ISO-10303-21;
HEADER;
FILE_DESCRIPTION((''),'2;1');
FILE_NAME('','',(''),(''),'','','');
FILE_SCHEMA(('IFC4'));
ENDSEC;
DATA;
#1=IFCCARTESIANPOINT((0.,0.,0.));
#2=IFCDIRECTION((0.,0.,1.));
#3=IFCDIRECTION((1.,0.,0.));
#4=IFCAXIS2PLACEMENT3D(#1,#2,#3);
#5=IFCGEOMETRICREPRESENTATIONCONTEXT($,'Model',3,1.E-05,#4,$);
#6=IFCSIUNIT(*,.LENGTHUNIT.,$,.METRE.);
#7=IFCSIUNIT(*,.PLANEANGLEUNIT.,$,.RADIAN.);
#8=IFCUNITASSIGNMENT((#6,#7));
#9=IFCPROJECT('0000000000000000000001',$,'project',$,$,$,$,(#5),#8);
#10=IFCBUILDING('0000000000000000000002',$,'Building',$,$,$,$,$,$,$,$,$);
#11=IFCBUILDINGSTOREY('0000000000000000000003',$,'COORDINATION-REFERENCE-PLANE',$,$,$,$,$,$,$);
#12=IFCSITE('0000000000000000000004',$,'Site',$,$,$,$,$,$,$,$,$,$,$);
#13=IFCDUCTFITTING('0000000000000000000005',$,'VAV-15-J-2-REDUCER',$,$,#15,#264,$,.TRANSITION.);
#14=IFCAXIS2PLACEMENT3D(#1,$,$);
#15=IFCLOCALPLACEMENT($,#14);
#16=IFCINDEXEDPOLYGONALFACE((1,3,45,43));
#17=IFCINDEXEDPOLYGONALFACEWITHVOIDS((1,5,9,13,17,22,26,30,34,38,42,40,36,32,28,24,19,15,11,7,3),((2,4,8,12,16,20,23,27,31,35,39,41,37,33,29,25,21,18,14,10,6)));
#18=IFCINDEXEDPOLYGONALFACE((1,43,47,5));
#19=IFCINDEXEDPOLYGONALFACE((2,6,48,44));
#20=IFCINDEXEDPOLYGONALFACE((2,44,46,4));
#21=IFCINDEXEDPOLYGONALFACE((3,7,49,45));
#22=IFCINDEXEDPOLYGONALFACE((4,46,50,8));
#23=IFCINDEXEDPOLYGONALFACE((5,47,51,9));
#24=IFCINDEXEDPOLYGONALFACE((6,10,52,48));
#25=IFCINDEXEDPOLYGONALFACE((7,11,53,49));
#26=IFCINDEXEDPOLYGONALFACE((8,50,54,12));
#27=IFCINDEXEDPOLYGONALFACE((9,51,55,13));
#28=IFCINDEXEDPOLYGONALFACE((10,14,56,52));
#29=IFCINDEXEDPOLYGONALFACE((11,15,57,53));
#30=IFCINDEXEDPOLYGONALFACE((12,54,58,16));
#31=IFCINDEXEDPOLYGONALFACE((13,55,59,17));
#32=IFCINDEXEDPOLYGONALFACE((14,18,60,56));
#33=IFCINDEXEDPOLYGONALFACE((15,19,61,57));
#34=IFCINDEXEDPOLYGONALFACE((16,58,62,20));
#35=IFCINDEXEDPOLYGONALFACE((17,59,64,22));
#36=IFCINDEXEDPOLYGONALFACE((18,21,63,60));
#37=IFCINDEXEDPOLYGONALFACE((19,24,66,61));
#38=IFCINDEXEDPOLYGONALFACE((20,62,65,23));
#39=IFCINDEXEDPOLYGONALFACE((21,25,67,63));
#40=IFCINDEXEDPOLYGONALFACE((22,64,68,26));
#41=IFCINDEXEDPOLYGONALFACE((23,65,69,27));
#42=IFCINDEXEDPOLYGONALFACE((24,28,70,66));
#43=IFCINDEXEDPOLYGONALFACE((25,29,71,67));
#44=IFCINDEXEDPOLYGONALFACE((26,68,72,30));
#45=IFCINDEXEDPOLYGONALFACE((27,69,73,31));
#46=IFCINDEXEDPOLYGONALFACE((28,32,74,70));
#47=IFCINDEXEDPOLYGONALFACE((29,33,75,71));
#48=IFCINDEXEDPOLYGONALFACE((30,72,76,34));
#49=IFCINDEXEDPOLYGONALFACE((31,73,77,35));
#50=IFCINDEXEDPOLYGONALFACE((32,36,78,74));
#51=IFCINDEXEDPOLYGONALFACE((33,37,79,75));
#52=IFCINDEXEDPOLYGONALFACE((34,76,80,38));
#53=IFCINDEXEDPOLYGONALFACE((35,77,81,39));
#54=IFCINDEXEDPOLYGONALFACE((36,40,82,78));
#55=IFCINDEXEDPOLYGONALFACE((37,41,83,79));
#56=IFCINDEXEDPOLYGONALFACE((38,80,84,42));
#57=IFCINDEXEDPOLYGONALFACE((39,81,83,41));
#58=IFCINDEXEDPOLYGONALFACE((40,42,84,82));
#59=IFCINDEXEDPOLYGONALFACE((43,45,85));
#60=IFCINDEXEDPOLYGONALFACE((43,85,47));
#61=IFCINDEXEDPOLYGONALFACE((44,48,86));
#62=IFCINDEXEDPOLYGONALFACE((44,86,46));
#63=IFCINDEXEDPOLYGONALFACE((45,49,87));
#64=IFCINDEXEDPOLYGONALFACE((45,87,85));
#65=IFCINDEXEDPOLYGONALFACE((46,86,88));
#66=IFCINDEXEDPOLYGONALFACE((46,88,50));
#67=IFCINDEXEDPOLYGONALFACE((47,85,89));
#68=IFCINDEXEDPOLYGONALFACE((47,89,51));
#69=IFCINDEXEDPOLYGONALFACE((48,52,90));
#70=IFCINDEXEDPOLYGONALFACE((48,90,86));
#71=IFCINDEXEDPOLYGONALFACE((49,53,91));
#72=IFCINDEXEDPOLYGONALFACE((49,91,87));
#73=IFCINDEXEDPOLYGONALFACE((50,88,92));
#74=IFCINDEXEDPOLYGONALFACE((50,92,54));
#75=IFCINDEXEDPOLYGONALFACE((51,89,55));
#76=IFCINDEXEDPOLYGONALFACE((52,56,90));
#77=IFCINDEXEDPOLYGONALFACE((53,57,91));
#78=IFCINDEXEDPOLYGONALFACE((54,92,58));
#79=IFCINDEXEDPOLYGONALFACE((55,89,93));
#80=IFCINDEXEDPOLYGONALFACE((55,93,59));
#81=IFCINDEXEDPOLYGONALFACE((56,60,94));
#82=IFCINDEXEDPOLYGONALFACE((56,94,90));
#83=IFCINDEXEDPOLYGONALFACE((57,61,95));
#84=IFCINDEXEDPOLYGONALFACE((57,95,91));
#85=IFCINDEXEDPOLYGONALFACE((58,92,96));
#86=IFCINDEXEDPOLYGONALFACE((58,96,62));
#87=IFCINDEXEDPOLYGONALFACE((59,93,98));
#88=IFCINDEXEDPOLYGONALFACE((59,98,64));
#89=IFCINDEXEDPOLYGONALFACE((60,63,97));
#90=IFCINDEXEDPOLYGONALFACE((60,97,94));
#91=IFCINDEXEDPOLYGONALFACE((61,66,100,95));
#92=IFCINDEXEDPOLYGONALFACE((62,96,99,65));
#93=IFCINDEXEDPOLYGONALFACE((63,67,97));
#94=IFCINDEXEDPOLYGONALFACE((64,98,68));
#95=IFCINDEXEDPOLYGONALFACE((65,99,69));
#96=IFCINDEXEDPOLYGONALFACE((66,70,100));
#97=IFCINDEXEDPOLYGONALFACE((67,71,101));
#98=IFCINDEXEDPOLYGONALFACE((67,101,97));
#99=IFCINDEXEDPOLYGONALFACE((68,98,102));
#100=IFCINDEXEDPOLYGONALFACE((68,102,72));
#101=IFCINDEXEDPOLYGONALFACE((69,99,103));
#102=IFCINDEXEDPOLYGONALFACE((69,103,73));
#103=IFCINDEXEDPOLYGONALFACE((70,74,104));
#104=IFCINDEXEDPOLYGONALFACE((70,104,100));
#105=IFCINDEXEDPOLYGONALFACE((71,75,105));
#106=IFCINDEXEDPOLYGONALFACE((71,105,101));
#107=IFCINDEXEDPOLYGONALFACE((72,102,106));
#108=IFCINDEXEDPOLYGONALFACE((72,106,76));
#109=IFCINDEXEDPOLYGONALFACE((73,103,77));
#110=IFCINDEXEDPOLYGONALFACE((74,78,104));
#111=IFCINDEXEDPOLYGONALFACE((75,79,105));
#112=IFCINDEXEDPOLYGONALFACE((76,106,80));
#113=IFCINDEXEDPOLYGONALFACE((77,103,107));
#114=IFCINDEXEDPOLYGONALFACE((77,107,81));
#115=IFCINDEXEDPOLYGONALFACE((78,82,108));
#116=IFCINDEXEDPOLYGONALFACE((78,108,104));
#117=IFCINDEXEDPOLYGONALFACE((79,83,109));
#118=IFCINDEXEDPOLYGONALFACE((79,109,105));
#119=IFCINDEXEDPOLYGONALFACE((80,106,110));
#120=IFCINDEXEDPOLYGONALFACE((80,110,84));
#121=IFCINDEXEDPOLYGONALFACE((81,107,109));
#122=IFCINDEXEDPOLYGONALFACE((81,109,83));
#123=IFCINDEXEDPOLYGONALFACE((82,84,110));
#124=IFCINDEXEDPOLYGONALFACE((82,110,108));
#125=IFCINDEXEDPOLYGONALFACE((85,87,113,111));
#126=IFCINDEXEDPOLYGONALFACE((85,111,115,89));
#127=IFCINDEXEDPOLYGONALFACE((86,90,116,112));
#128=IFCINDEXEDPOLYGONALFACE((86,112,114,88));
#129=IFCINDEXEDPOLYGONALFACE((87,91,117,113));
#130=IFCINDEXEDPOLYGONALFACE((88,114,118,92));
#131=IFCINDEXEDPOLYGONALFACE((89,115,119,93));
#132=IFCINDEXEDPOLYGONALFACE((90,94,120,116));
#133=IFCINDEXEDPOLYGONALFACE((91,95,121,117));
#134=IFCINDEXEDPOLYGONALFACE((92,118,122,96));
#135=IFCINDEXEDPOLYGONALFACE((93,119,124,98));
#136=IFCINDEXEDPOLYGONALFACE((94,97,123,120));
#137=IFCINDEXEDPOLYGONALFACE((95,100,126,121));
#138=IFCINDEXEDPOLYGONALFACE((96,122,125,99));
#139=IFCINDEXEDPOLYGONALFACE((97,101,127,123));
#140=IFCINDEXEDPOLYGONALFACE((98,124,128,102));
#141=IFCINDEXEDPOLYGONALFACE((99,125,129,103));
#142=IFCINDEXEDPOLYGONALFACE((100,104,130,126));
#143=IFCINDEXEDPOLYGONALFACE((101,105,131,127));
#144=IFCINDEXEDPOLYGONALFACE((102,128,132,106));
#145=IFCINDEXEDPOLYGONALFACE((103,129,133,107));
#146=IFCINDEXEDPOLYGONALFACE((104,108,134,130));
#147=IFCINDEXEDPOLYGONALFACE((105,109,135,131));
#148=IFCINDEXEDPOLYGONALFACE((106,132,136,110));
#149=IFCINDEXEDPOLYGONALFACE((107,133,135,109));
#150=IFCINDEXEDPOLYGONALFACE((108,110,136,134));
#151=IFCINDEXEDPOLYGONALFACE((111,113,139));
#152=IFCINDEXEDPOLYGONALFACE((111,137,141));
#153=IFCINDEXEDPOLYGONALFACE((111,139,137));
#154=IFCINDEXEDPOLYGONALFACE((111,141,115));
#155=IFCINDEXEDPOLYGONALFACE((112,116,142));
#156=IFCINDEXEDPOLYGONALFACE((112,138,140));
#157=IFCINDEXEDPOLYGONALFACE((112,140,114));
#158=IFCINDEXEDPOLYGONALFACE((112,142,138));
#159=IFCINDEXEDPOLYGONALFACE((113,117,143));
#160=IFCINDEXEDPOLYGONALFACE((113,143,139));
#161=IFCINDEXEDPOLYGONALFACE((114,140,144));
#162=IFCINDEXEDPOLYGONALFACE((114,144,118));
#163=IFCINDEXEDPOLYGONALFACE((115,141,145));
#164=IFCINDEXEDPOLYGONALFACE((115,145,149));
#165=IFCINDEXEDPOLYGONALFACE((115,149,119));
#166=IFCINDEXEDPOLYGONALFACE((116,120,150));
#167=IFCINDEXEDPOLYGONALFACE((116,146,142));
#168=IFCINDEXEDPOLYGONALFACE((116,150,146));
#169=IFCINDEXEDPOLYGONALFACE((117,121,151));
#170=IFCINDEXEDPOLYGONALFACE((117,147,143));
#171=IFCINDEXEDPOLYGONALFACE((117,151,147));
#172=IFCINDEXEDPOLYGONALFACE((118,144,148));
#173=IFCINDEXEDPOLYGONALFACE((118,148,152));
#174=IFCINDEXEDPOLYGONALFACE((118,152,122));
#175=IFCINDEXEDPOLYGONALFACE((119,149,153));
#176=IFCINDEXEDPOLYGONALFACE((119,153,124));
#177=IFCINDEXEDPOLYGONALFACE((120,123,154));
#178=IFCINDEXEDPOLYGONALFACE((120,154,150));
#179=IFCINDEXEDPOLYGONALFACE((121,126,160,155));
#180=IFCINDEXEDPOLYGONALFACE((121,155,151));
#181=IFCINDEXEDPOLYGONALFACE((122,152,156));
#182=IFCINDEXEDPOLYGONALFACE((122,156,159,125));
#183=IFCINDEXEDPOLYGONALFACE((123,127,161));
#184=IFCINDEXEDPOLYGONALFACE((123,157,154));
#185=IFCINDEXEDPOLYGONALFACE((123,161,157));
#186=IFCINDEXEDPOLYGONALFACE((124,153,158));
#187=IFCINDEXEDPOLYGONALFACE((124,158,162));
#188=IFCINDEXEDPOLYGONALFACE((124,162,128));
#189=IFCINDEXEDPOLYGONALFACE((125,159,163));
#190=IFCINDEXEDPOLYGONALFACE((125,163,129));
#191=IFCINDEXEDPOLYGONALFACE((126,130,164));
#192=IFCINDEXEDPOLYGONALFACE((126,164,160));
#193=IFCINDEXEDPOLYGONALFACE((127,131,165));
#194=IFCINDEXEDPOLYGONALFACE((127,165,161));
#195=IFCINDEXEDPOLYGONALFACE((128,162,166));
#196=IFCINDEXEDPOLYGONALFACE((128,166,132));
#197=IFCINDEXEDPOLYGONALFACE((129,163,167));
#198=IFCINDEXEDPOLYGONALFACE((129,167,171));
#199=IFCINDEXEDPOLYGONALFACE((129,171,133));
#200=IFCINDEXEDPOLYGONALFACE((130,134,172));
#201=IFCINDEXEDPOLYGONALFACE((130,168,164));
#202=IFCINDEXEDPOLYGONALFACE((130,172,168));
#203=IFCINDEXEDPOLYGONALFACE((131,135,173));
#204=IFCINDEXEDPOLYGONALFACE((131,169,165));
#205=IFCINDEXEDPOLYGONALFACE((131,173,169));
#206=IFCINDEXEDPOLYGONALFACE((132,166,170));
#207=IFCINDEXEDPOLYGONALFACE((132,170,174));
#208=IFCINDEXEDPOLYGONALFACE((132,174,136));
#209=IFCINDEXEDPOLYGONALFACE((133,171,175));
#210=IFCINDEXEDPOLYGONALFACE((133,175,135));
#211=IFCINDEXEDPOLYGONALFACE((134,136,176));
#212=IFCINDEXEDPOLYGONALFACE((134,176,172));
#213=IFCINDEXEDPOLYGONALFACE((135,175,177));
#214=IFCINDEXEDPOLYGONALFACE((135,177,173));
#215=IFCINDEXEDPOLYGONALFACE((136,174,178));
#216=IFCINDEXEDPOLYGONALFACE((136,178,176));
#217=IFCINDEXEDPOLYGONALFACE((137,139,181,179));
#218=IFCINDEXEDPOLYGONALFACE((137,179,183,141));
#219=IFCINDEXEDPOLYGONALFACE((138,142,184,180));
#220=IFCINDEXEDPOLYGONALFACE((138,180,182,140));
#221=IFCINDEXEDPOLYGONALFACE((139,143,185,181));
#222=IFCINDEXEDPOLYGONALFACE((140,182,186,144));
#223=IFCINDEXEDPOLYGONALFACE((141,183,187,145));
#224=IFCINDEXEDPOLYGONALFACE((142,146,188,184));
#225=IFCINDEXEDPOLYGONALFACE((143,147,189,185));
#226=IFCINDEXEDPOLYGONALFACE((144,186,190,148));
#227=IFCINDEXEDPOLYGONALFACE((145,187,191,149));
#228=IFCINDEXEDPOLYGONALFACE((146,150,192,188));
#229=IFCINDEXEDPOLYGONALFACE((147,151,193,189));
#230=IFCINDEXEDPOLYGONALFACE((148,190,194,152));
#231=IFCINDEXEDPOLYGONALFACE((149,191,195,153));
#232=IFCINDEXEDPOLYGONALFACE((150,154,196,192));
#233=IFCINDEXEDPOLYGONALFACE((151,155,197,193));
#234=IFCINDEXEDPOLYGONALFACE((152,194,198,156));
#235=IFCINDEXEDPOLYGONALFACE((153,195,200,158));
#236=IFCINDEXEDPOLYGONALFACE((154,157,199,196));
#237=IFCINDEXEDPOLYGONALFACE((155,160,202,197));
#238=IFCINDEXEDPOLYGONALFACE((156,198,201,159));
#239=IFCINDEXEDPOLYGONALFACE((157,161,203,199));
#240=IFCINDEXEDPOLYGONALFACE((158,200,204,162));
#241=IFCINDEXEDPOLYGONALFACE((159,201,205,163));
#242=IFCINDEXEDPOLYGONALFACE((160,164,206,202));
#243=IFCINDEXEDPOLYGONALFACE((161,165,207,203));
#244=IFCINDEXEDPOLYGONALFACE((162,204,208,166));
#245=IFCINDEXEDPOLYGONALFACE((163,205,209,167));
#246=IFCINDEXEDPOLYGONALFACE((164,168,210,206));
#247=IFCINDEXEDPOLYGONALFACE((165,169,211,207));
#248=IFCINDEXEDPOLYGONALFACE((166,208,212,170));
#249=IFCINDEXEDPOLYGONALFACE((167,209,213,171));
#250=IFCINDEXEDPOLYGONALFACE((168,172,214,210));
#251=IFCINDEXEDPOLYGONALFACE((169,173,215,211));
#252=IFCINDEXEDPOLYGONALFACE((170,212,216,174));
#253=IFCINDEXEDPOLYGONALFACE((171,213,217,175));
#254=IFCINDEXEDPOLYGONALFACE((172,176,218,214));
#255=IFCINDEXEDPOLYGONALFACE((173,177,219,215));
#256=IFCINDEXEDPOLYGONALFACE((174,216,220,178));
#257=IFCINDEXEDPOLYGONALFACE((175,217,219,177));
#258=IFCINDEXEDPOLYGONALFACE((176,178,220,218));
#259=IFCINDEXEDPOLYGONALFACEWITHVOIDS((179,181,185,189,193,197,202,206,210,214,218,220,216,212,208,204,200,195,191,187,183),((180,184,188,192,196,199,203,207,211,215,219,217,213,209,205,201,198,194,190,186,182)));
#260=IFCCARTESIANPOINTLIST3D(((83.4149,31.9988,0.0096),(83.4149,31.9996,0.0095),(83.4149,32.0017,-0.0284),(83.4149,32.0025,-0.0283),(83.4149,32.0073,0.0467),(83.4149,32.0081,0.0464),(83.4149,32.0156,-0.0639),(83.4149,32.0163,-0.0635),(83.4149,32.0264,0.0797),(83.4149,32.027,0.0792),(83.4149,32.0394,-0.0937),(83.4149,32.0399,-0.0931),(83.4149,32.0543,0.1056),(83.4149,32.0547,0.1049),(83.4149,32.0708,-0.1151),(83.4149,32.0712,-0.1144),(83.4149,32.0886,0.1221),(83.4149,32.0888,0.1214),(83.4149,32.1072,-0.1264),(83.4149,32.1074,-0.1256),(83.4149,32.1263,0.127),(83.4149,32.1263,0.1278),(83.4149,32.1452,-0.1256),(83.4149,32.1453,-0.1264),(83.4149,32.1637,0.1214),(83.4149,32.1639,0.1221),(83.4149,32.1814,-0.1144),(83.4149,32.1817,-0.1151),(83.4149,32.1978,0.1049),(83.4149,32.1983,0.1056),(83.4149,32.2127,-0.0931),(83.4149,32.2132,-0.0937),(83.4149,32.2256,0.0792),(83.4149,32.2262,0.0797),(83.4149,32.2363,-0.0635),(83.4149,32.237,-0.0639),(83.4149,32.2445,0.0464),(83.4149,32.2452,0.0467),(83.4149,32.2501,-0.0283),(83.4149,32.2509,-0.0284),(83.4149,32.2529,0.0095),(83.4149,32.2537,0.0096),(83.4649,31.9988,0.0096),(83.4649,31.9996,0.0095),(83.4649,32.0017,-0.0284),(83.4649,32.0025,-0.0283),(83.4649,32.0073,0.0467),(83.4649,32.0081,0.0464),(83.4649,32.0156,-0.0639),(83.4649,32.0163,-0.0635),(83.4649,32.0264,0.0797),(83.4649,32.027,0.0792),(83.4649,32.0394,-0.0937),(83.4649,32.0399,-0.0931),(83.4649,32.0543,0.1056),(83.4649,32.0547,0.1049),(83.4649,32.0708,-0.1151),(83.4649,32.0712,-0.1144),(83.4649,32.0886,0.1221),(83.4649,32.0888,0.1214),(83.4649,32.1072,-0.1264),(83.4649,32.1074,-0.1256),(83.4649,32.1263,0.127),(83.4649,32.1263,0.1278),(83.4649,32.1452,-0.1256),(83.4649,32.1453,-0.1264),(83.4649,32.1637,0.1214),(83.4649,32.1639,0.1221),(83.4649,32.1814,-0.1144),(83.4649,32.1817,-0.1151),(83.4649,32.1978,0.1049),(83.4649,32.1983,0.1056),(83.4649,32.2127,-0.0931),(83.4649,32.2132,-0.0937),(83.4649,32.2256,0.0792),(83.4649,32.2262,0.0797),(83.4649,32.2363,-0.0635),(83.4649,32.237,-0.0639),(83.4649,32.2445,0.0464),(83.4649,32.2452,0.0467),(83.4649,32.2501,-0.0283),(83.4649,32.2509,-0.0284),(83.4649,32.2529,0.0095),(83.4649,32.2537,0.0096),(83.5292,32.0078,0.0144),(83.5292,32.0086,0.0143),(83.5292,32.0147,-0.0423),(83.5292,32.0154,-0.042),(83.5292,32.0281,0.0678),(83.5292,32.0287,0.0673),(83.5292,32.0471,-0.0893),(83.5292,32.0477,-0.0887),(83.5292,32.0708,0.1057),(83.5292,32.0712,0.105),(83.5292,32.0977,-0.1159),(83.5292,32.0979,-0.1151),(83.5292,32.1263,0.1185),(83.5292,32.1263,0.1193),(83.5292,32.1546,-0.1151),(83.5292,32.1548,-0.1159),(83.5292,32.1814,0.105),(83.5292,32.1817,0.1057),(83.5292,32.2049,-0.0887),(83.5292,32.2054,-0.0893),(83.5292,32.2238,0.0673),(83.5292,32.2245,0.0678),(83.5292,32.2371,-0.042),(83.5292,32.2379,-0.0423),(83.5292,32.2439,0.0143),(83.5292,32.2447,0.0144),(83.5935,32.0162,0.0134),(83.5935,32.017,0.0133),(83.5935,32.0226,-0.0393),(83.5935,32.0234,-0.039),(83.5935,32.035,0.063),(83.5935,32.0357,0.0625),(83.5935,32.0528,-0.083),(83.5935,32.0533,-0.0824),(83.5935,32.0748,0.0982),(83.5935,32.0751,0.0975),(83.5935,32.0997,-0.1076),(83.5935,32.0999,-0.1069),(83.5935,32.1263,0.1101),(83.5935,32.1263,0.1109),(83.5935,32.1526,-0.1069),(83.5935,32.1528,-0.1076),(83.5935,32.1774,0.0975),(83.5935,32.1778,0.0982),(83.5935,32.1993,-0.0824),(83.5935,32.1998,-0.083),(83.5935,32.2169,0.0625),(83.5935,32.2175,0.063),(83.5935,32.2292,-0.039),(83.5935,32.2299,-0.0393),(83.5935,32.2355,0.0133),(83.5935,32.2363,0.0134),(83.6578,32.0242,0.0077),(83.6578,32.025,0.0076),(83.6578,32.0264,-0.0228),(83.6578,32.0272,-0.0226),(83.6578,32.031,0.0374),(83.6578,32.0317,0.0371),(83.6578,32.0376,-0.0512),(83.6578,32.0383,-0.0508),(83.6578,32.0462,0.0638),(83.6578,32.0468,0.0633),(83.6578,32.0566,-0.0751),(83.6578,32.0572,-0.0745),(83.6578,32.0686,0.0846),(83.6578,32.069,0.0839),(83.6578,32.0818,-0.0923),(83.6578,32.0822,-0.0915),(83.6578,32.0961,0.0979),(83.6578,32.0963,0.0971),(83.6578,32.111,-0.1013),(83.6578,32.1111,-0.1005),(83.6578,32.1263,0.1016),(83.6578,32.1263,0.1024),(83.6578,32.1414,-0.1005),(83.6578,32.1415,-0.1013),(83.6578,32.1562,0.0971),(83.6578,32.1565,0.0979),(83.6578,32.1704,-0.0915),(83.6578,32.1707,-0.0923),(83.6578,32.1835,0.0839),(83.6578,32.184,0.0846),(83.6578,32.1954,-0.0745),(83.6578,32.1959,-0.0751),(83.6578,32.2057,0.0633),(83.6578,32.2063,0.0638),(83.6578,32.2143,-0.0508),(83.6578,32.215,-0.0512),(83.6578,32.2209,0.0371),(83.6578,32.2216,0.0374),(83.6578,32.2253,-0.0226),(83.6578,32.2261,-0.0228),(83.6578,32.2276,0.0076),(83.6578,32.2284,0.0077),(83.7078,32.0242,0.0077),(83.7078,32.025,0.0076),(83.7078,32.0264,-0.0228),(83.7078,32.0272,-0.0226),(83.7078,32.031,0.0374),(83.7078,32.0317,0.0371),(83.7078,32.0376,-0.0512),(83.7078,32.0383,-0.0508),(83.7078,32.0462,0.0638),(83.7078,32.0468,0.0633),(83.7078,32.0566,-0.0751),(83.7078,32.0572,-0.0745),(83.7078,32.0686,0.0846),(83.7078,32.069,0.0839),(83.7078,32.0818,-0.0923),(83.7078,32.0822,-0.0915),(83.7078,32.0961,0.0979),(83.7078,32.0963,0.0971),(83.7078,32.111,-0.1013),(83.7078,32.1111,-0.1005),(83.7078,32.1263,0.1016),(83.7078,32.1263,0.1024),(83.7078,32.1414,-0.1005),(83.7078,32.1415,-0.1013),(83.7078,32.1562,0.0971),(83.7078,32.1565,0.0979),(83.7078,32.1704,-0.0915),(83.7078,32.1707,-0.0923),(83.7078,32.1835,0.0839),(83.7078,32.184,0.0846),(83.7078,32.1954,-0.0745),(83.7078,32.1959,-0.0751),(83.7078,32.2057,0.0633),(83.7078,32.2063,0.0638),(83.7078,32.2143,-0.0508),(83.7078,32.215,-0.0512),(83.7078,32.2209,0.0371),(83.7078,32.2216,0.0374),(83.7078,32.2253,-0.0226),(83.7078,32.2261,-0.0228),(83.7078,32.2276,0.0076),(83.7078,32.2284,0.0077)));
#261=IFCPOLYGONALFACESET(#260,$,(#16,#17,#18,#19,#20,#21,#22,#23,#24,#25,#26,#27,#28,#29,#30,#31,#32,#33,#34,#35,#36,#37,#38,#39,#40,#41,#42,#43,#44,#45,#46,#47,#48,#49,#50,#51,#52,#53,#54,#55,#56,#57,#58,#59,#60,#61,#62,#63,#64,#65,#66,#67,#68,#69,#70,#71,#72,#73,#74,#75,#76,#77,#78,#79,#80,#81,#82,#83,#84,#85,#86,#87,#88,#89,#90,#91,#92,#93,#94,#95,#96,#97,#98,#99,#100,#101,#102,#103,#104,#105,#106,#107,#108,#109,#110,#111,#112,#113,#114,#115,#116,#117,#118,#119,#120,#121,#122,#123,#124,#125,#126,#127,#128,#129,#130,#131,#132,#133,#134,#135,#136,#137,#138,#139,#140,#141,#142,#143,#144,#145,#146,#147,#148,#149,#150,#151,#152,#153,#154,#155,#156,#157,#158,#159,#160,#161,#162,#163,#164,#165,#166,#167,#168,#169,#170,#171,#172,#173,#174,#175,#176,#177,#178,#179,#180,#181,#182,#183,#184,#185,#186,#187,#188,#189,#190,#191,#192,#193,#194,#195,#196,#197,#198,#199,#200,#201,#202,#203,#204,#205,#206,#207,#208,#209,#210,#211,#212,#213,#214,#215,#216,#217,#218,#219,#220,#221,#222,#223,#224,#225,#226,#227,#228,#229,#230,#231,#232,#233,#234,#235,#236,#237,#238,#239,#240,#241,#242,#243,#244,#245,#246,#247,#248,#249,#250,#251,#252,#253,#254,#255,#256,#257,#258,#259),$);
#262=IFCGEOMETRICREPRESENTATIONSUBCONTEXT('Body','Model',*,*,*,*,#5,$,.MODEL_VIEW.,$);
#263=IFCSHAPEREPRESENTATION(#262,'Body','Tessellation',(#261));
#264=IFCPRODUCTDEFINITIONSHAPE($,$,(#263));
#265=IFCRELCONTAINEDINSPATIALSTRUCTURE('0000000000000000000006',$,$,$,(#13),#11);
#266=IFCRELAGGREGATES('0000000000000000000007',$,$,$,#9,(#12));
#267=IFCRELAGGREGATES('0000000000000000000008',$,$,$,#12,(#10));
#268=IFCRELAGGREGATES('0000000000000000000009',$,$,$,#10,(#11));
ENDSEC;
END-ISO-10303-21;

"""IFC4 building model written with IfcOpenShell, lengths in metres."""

from ifc_helpers import new_model, entity, si_unit, frame, origin_with_axes, place, context, subcontext, project, spatial, element, save


model = new_model("IFC4")

# Units and contexts
model_context = context("Model", 3, precision=1e-05, world=origin_with_axes())
body_context_1 = subcontext(model_context, "Body", "Model", "MODEL_VIEW")
ifc_project = project(units=[si_unit("LENGTHUNIT", "METRE"), si_unit("PLANEANGLEUNIT", "RADIAN")], contexts=[model_context])

# Site, building, storey
site = spatial("IfcSite", under=ifc_project, Name="Site")
building = spatial("IfcBuilding", under=site, Name="Building")
storey = spatial("IfcBuildingStorey", under=building, Name="COORDINATION-REFERENCE-PLANE")

# Duct fitting
for number, where, z_axis, x_axis, name in (
    (1, (83.4149, 32.1263, 0.0), (0.0, 1.0, 0.0), (0.0, 0.0, 1.0), "VAV-15-J-2-REDUCER"),
):
    element("IfcDuctFitting", number, at=place(None, frame(where, z_axis=z_axis, x_axis=x_axis)), inside=storey, Name=name, PredefinedType="TRANSITION", context=body_context_1, shape_type="SweptSolid", body=[
        entity("IfcRevolvedAreaSolid", entity("IfcArbitraryClosedProfileDef", "AREA", None, entity("IfcPolyline", [entity("IfcCartesianPoint", [0.1278, 0.0]), entity("IfcCartesianPoint", [0.1278, 0.05]), entity("IfcCartesianPoint", [0.1024, 0.2429]), entity("IfcCartesianPoint", [0.1024, 0.2929]), entity("IfcCartesianPoint", [0.1016, 0.2929]), entity("IfcCartesianPoint", [0.1016, 0.2429]), entity("IfcCartesianPoint", [0.127, 0.05]), entity("IfcCartesianPoint", [0.127, 0.0]), entity("IfcCartesianPoint", [0.1278, 0.0])])), entity("IfcAxis2Placement3D", entity("IfcCartesianPoint", [0.0, 0.0, 0.0])), entity("IfcAxis1Placement", entity("IfcCartesianPoint", [0.0, 0.0, 0.0]), entity("IfcDirection", [0.0, 1.0, 0.0])), 6.283185),
    ])

save(model, "model.ifc")
